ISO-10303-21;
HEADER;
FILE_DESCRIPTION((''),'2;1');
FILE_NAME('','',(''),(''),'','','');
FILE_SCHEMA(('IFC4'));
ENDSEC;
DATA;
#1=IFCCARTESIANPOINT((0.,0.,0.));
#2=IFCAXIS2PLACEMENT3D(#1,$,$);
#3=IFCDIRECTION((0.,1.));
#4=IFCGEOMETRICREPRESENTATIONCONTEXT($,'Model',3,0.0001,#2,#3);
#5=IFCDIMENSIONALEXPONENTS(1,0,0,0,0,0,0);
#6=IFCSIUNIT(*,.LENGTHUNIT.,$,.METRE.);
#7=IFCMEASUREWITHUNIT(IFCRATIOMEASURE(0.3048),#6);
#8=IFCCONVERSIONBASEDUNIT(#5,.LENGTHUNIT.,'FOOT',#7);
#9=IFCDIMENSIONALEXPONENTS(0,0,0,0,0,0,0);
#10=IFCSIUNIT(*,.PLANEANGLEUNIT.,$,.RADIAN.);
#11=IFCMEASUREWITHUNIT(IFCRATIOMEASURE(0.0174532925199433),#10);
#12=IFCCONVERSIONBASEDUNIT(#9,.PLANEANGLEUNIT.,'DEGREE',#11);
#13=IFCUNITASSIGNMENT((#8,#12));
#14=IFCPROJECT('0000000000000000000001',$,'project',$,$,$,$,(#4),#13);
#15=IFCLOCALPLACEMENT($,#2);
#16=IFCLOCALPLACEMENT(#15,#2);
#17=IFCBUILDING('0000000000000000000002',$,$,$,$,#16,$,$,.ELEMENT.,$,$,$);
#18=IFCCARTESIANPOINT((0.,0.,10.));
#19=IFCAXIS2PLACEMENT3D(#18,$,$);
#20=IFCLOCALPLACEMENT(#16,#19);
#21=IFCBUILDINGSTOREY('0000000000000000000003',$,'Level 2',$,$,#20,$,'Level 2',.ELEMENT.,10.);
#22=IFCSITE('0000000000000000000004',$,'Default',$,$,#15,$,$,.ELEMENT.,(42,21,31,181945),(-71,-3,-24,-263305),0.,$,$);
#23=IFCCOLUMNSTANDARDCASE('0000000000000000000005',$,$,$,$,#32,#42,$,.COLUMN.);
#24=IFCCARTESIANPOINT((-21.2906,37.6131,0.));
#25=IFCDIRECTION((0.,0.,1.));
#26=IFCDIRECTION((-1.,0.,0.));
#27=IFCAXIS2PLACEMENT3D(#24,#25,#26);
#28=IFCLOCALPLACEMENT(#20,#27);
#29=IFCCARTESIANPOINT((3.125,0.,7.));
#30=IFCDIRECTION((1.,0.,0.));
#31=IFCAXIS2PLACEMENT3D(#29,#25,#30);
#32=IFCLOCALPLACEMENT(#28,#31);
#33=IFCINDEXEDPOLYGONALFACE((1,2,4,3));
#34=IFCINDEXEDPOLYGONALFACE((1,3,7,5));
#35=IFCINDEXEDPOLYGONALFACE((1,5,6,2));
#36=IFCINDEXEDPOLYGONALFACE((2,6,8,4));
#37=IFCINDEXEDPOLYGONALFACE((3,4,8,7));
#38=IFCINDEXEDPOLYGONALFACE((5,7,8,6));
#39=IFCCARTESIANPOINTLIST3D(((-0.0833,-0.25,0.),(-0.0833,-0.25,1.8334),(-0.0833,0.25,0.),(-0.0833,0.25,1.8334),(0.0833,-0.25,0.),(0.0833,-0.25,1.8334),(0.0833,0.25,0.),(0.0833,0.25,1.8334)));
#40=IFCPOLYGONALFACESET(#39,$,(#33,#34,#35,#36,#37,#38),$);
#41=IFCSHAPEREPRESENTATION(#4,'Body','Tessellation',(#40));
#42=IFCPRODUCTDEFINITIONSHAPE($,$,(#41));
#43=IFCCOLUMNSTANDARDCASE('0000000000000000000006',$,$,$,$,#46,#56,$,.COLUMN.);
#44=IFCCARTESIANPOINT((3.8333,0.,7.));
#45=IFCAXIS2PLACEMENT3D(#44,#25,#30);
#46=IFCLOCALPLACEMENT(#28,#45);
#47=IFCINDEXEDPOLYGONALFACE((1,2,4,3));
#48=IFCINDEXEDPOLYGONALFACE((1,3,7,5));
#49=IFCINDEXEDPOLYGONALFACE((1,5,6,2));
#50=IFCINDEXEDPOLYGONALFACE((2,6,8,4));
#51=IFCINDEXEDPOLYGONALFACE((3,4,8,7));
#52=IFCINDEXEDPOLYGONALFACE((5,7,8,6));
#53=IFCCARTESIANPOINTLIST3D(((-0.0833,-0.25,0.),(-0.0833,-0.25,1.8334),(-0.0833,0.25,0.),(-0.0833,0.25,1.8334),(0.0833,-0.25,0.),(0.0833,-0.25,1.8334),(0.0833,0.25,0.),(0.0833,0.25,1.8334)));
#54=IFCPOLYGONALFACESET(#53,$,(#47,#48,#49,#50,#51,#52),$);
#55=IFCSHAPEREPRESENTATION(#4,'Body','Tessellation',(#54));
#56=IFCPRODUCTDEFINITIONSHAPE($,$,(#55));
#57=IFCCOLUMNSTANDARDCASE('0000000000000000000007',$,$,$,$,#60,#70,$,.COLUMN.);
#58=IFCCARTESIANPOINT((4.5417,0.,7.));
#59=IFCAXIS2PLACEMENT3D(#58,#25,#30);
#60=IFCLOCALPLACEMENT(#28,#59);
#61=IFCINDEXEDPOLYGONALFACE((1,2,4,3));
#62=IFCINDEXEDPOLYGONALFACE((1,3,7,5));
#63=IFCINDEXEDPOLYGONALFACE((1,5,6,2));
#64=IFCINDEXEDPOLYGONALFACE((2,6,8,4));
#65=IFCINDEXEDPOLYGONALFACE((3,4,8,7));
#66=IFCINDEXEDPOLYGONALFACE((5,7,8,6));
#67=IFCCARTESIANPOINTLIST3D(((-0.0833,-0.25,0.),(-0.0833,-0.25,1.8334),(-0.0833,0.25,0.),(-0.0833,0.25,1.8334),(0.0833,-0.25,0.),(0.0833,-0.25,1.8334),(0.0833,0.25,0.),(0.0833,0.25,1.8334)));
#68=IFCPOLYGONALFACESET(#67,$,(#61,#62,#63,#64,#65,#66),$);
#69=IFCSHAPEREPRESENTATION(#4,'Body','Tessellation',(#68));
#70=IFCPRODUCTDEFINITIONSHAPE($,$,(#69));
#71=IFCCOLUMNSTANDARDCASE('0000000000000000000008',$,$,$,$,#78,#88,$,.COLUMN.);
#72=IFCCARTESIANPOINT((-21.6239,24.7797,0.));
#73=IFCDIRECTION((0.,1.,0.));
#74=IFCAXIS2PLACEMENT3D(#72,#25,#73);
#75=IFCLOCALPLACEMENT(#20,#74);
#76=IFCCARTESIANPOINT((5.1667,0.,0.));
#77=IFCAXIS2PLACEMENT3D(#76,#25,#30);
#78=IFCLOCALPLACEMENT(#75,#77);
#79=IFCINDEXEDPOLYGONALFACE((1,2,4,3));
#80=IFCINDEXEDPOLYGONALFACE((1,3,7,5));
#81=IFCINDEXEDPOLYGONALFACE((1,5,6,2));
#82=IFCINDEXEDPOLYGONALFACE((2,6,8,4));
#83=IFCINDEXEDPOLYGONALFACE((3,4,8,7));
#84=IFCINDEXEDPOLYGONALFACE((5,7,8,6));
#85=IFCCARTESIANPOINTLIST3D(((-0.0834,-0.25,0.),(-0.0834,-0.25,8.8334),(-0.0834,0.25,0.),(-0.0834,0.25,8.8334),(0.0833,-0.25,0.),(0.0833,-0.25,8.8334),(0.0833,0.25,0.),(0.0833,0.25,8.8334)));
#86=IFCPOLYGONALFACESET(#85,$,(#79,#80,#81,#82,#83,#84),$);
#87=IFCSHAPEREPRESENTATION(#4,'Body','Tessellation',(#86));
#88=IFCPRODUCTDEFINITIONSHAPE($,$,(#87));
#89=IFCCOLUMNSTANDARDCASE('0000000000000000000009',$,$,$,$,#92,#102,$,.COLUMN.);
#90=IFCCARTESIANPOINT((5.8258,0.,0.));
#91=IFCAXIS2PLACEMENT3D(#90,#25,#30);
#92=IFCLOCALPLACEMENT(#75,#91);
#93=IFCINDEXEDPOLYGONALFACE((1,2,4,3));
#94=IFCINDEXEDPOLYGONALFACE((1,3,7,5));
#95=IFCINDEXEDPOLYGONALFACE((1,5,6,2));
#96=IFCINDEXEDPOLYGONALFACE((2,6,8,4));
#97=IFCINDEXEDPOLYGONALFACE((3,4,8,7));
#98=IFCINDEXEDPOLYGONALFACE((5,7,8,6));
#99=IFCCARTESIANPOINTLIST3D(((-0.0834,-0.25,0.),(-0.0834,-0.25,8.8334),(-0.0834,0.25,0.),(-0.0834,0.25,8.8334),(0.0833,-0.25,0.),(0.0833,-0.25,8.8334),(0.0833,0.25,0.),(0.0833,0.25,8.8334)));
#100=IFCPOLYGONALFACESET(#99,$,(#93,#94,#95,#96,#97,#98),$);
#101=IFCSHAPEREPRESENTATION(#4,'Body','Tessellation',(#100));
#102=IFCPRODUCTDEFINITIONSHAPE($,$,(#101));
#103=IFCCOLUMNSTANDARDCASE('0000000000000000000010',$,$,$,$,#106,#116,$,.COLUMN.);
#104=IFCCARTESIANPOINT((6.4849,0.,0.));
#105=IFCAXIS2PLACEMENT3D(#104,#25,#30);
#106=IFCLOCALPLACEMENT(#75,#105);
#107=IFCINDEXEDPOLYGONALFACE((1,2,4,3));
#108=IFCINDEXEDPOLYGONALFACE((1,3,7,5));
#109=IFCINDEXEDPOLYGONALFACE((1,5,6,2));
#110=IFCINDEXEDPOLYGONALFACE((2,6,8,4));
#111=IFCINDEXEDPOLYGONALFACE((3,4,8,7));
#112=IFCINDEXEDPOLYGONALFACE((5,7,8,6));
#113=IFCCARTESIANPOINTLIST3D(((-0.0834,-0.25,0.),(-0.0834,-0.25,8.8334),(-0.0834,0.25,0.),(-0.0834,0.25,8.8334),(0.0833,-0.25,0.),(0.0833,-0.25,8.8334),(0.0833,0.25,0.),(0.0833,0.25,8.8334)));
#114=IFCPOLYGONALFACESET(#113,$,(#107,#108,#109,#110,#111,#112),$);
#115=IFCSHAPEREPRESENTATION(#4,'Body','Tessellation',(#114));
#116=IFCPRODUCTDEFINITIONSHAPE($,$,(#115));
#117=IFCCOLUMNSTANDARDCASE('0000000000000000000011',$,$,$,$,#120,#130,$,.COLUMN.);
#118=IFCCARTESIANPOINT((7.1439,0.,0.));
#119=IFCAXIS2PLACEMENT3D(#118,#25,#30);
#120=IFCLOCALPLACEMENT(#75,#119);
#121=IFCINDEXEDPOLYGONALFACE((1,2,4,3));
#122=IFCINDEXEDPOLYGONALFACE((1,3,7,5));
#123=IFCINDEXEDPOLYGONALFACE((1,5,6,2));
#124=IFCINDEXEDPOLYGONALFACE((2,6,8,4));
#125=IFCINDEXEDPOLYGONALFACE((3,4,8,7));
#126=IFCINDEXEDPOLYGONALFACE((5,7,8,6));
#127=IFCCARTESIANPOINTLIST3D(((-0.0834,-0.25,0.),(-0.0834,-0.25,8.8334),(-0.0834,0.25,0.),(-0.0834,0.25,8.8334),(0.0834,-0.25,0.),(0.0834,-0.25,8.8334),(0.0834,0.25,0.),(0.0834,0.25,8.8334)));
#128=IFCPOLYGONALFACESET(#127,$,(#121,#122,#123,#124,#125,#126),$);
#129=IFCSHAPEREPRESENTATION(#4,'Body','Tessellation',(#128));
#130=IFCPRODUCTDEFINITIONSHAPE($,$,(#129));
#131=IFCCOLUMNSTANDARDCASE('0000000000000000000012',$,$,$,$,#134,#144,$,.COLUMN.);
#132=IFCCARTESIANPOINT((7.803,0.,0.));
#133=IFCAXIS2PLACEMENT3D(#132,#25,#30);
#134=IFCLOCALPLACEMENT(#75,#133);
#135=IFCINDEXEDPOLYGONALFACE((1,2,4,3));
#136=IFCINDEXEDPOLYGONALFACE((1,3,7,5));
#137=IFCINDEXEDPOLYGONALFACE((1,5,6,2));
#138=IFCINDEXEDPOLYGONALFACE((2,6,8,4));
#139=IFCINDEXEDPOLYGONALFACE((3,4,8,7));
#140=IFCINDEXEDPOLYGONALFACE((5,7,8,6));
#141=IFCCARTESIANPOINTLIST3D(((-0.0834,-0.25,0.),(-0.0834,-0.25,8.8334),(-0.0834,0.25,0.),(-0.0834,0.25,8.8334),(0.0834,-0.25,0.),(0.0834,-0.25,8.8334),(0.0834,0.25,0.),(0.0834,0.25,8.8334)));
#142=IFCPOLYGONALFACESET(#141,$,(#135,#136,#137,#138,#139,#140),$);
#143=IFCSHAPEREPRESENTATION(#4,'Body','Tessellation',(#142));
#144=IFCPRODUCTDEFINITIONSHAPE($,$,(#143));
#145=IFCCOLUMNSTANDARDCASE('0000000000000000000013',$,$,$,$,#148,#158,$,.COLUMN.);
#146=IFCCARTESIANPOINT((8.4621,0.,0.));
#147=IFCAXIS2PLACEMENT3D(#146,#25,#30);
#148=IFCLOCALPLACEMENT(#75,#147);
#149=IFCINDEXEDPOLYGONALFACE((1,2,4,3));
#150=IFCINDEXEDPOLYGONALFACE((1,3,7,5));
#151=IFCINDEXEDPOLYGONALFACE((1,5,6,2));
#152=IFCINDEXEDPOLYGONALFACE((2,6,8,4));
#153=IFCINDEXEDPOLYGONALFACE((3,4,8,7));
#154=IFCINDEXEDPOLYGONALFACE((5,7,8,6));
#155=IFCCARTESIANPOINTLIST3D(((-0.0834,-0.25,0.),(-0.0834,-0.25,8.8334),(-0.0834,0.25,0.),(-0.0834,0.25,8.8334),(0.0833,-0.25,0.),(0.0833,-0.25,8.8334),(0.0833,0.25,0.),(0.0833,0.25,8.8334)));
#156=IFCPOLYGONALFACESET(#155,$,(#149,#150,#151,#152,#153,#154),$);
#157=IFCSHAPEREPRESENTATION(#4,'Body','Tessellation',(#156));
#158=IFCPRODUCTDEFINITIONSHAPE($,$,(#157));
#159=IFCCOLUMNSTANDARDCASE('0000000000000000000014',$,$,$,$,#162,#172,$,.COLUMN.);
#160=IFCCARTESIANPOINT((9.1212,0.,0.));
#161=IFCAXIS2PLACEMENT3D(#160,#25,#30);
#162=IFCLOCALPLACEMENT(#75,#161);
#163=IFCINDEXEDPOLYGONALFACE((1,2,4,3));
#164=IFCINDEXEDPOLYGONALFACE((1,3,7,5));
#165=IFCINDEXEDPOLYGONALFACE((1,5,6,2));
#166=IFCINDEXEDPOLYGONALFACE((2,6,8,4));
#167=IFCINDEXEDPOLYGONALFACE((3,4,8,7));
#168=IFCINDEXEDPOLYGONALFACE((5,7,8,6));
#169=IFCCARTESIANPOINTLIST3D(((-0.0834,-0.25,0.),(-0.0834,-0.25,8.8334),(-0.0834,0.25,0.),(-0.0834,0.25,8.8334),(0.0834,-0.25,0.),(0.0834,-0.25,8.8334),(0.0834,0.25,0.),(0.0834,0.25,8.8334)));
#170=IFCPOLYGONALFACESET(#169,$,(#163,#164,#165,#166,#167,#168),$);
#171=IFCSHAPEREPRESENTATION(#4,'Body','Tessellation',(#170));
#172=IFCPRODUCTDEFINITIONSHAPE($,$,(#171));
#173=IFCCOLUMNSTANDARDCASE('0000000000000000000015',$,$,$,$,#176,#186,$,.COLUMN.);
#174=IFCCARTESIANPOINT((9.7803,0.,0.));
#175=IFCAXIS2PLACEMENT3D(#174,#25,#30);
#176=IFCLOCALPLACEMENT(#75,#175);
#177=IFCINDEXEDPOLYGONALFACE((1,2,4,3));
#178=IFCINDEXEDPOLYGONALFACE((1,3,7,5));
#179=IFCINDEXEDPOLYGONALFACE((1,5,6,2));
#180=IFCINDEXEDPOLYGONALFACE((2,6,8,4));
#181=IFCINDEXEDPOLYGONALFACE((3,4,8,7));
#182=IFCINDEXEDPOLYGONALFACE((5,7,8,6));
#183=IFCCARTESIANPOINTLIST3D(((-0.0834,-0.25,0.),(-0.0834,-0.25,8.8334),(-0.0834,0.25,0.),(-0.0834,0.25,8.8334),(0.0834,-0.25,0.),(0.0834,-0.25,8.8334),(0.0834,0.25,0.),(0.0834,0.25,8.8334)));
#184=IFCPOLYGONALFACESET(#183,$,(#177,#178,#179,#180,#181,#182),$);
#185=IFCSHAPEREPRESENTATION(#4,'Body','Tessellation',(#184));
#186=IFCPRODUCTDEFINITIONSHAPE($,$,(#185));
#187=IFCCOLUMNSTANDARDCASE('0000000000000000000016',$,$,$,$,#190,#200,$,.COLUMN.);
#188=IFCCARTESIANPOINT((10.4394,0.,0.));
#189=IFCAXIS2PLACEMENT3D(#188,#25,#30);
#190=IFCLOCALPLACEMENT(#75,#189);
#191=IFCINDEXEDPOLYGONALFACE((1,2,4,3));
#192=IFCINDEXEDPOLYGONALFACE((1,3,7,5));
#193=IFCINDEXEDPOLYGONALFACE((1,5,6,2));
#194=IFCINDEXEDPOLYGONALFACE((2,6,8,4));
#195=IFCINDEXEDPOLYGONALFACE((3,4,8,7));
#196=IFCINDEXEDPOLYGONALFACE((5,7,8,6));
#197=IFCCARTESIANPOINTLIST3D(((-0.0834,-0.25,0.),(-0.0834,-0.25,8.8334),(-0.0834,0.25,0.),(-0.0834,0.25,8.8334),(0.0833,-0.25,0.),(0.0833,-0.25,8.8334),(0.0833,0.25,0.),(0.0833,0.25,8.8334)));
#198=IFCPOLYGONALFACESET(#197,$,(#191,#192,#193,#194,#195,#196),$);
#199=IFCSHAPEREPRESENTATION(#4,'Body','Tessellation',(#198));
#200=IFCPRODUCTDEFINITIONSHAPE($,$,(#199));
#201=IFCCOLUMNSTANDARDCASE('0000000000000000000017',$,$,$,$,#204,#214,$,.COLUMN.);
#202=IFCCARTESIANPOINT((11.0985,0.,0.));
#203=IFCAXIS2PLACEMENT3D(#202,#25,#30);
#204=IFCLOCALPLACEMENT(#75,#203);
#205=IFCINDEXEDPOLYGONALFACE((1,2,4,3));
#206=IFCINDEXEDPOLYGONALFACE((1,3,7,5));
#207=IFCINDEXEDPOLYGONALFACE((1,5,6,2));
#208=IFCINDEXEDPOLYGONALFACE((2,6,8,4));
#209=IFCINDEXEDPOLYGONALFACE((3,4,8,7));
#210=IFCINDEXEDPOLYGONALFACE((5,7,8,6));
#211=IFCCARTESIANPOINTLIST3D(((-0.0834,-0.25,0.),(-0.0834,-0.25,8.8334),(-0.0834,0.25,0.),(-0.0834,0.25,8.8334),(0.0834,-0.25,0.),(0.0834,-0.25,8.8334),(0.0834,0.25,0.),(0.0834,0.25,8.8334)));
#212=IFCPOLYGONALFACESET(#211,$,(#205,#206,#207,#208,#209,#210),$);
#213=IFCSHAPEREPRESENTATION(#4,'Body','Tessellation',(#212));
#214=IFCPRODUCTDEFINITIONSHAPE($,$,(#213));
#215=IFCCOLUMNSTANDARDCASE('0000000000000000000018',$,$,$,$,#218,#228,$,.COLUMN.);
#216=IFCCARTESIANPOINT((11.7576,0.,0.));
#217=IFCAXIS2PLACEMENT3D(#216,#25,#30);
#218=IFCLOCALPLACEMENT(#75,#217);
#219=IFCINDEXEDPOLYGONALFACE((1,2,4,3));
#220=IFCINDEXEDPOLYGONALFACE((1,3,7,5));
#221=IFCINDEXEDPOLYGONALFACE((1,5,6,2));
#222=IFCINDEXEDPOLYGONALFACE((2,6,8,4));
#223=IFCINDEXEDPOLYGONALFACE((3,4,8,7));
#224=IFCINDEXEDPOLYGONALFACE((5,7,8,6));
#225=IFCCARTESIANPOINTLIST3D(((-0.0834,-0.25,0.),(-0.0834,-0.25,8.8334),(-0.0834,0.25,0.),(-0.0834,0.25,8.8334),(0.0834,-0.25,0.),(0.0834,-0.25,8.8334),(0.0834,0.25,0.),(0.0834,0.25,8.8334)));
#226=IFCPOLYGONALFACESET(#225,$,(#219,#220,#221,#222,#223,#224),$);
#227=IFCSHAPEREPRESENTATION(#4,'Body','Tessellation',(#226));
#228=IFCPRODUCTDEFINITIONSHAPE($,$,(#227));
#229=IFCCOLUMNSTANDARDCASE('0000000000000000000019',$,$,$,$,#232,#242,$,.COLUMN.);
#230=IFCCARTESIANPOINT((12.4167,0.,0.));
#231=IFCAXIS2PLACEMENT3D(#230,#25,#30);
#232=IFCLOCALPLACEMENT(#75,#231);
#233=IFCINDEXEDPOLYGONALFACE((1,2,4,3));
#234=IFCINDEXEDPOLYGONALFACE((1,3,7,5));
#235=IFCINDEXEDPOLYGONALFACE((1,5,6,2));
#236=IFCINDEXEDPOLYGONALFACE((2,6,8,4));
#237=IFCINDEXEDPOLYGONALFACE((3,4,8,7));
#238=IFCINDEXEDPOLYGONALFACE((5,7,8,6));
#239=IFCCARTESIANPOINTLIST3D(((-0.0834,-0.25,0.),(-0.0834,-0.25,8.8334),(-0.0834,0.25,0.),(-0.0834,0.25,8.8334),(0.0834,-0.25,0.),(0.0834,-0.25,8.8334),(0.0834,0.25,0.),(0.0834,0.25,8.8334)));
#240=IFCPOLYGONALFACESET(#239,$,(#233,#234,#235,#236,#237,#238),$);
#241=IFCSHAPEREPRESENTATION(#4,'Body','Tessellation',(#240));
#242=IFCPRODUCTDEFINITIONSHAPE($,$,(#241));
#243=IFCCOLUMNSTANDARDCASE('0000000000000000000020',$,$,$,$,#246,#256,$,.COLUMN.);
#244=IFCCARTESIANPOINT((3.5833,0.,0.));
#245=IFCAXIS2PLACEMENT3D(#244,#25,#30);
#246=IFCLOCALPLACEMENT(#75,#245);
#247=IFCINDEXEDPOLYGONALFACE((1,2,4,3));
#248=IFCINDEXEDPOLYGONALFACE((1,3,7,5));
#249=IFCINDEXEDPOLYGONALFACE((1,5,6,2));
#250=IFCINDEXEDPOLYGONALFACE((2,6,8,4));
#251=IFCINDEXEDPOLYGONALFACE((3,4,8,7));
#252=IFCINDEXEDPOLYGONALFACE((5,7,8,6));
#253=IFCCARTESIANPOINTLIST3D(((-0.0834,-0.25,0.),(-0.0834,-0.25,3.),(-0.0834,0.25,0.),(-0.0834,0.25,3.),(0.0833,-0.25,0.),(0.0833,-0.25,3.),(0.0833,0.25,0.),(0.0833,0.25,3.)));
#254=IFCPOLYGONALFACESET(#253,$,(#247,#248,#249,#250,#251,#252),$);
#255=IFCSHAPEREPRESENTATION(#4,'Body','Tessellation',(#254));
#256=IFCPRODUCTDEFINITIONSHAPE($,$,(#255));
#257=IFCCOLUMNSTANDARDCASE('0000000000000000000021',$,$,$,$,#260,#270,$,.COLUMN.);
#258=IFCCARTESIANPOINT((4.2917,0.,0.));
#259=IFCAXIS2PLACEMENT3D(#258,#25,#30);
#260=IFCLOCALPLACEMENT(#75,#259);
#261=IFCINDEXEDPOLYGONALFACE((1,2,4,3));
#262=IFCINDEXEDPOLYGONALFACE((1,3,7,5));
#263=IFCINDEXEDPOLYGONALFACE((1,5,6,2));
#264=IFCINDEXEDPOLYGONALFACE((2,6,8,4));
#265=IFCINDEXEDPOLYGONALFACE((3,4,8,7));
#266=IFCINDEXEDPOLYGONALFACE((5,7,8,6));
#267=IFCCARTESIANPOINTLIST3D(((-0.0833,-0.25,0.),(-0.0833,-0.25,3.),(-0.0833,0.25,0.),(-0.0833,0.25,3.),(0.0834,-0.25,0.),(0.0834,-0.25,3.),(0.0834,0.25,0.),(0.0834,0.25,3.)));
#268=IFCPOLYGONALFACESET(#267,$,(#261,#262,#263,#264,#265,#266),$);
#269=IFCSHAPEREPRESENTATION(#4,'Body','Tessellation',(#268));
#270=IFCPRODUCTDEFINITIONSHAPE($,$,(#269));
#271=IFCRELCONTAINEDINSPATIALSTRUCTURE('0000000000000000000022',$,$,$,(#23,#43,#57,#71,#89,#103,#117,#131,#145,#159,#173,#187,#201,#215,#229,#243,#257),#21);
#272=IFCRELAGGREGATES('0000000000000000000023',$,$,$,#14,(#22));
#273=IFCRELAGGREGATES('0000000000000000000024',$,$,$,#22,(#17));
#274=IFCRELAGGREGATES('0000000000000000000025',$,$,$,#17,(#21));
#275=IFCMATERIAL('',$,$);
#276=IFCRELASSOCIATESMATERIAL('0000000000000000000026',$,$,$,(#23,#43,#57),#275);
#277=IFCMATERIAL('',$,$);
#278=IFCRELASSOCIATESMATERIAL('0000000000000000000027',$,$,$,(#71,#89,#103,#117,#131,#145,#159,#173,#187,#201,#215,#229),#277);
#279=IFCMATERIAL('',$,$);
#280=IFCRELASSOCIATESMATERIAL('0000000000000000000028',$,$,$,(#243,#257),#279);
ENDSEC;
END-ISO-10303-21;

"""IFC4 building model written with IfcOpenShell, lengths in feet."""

from ifc_helpers import new_model, entity, si_unit, converted_unit, direction, frame, origin, place, context, project, spatial, rectangle, extrude, material, element, save


model = new_model("IFC4")

# Units and contexts
model_context = context("Model", 3, precision=0.0001, world=origin(), true_north=direction((0.0, 1.0)))
ifc_project = project(units=[converted_unit("LENGTHUNIT", "FOOT", entity("IfcRatioMeasure", 0.3048), si_unit("LENGTHUNIT", "METRE"), dimensions=[1, 0, 0, 0, 0, 0, 0]), converted_unit("PLANEANGLEUNIT", "DEGREE", entity("IfcRatioMeasure", 0.0174532925199433), si_unit("PLANEANGLEUNIT", "RADIAN"), dimensions=[0, 0, 0, 0, 0, 0, 0])], contexts=[model_context])

# Site, building, storey
site_placement = place(None, origin())
site = spatial("IfcSite", under=ifc_project, at=site_placement, Name="Default", CompositionType="ELEMENT", RefLatitude=(42, 21, 31, 181945), RefLongitude=(-71, -3, -24, -263305), RefElevation=0.0)
building_placement = place(site_placement, origin())
building = spatial("IfcBuilding", under=site, at=building_placement, CompositionType="ELEMENT")
storey_placement = place(building_placement, frame((0.0, 0.0, 10.0)))
storey = spatial("IfcBuildingStorey", under=building, at=storey_placement, Name="Level 2", LongName="Level 2", CompositionType="ELEMENT", Elevation=10.0)

# Columns
ifc_material_1 = material(Name="")
placement_1 = place(storey_placement, frame((-21.2906, 37.6131, 0.0), z_axis=(0.0, 0.0, 1.0), x_axis=(-1.0, 0.0, 0.0)))
for number, where, z_axis, x_axis in (
    (1, (3.125, 0.0, 7.0), (0.0, 0.0, 1.0), (1.0, 0.0, 0.0)),
    (2, (3.8333, 0.0, 7.0), (0.0, 0.0, 1.0), (1.0, 0.0, 0.0)),
    (3, (4.5417, 0.0, 7.0), (0.0, 0.0, 1.0), (1.0, 0.0, 0.0)),
):
    element("IfcColumnStandardCase", number, at=place(placement_1, frame(where, z_axis=z_axis, x_axis=x_axis)), inside=storey, material=ifc_material_1, PredefinedType="COLUMN", context=model_context, shape_type="SweptSolid", body=[
        extrude(rectangle(XDim=0.1667, YDim=0.5), origin(), (0.0, 0.0, 1.0), 1.8334),
    ])
ifc_material_2 = material(Name="")
placement_2 = place(storey_placement, frame((-21.6239, 24.7797, 0.0), z_axis=(0.0, 0.0, 1.0), x_axis=(0.0, 1.0, 0.0)))
for number, where, z_axis, x_axis in (
    (4, (5.1667, 0.0, 0.0), (0.0, 0.0, 1.0), (1.0, 0.0, 0.0)),
    (5, (5.8258, 0.0, 0.0), (0.0, 0.0, 1.0), (1.0, 0.0, 0.0)),
    (6, (6.4849, 0.0, 0.0), (0.0, 0.0, 1.0), (1.0, 0.0, 0.0)),
    (7, (7.1439, 0.0, 0.0), (0.0, 0.0, 1.0), (1.0, 0.0, 0.0)),
    (8, (7.803, 0.0, 0.0), (0.0, 0.0, 1.0), (1.0, 0.0, 0.0)),
    (9, (8.4621, 0.0, 0.0), (0.0, 0.0, 1.0), (1.0, 0.0, 0.0)),
    (10, (9.1212, 0.0, 0.0), (0.0, 0.0, 1.0), (1.0, 0.0, 0.0)),
    (11, (9.7803, 0.0, 0.0), (0.0, 0.0, 1.0), (1.0, 0.0, 0.0)),
    (12, (10.4394, 0.0, 0.0), (0.0, 0.0, 1.0), (1.0, 0.0, 0.0)),
    (13, (11.0985, 0.0, 0.0), (0.0, 0.0, 1.0), (1.0, 0.0, 0.0)),
    (14, (11.7576, 0.0, 0.0), (0.0, 0.0, 1.0), (1.0, 0.0, 0.0)),
    (15, (12.4167, 0.0, 0.0), (0.0, 0.0, 1.0), (1.0, 0.0, 0.0)),
):
    element("IfcColumnStandardCase", number, at=place(placement_2, frame(where, z_axis=z_axis, x_axis=x_axis)), inside=storey, material=ifc_material_2, PredefinedType="COLUMN", context=model_context, shape_type="SweptSolid", body=[
        extrude(rectangle(XDim=0.1667, YDim=0.5), origin(), (0.0, 0.0, 1.0), 8.8334),
    ])
ifc_material_3 = material(Name="")
for number, where, z_axis, x_axis in (
    (16, (3.5833, 0.0, 0.0), (0.0, 0.0, 1.0), (1.0, 0.0, 0.0)),
    (17, (4.2917, 0.0, 0.0), (0.0, 0.0, 1.0), (1.0, 0.0, 0.0)),
):
    element("IfcColumnStandardCase", number, at=place(placement_2, frame(where, z_axis=z_axis, x_axis=x_axis)), inside=storey, material=ifc_material_3, PredefinedType="COLUMN", context=model_context, shape_type="SweptSolid", body=[
        extrude(rectangle(XDim=0.1667, YDim=0.5), origin(), (0.0, 0.0, 1.0), 3.0),
    ])

save(model, "model.ifc")
